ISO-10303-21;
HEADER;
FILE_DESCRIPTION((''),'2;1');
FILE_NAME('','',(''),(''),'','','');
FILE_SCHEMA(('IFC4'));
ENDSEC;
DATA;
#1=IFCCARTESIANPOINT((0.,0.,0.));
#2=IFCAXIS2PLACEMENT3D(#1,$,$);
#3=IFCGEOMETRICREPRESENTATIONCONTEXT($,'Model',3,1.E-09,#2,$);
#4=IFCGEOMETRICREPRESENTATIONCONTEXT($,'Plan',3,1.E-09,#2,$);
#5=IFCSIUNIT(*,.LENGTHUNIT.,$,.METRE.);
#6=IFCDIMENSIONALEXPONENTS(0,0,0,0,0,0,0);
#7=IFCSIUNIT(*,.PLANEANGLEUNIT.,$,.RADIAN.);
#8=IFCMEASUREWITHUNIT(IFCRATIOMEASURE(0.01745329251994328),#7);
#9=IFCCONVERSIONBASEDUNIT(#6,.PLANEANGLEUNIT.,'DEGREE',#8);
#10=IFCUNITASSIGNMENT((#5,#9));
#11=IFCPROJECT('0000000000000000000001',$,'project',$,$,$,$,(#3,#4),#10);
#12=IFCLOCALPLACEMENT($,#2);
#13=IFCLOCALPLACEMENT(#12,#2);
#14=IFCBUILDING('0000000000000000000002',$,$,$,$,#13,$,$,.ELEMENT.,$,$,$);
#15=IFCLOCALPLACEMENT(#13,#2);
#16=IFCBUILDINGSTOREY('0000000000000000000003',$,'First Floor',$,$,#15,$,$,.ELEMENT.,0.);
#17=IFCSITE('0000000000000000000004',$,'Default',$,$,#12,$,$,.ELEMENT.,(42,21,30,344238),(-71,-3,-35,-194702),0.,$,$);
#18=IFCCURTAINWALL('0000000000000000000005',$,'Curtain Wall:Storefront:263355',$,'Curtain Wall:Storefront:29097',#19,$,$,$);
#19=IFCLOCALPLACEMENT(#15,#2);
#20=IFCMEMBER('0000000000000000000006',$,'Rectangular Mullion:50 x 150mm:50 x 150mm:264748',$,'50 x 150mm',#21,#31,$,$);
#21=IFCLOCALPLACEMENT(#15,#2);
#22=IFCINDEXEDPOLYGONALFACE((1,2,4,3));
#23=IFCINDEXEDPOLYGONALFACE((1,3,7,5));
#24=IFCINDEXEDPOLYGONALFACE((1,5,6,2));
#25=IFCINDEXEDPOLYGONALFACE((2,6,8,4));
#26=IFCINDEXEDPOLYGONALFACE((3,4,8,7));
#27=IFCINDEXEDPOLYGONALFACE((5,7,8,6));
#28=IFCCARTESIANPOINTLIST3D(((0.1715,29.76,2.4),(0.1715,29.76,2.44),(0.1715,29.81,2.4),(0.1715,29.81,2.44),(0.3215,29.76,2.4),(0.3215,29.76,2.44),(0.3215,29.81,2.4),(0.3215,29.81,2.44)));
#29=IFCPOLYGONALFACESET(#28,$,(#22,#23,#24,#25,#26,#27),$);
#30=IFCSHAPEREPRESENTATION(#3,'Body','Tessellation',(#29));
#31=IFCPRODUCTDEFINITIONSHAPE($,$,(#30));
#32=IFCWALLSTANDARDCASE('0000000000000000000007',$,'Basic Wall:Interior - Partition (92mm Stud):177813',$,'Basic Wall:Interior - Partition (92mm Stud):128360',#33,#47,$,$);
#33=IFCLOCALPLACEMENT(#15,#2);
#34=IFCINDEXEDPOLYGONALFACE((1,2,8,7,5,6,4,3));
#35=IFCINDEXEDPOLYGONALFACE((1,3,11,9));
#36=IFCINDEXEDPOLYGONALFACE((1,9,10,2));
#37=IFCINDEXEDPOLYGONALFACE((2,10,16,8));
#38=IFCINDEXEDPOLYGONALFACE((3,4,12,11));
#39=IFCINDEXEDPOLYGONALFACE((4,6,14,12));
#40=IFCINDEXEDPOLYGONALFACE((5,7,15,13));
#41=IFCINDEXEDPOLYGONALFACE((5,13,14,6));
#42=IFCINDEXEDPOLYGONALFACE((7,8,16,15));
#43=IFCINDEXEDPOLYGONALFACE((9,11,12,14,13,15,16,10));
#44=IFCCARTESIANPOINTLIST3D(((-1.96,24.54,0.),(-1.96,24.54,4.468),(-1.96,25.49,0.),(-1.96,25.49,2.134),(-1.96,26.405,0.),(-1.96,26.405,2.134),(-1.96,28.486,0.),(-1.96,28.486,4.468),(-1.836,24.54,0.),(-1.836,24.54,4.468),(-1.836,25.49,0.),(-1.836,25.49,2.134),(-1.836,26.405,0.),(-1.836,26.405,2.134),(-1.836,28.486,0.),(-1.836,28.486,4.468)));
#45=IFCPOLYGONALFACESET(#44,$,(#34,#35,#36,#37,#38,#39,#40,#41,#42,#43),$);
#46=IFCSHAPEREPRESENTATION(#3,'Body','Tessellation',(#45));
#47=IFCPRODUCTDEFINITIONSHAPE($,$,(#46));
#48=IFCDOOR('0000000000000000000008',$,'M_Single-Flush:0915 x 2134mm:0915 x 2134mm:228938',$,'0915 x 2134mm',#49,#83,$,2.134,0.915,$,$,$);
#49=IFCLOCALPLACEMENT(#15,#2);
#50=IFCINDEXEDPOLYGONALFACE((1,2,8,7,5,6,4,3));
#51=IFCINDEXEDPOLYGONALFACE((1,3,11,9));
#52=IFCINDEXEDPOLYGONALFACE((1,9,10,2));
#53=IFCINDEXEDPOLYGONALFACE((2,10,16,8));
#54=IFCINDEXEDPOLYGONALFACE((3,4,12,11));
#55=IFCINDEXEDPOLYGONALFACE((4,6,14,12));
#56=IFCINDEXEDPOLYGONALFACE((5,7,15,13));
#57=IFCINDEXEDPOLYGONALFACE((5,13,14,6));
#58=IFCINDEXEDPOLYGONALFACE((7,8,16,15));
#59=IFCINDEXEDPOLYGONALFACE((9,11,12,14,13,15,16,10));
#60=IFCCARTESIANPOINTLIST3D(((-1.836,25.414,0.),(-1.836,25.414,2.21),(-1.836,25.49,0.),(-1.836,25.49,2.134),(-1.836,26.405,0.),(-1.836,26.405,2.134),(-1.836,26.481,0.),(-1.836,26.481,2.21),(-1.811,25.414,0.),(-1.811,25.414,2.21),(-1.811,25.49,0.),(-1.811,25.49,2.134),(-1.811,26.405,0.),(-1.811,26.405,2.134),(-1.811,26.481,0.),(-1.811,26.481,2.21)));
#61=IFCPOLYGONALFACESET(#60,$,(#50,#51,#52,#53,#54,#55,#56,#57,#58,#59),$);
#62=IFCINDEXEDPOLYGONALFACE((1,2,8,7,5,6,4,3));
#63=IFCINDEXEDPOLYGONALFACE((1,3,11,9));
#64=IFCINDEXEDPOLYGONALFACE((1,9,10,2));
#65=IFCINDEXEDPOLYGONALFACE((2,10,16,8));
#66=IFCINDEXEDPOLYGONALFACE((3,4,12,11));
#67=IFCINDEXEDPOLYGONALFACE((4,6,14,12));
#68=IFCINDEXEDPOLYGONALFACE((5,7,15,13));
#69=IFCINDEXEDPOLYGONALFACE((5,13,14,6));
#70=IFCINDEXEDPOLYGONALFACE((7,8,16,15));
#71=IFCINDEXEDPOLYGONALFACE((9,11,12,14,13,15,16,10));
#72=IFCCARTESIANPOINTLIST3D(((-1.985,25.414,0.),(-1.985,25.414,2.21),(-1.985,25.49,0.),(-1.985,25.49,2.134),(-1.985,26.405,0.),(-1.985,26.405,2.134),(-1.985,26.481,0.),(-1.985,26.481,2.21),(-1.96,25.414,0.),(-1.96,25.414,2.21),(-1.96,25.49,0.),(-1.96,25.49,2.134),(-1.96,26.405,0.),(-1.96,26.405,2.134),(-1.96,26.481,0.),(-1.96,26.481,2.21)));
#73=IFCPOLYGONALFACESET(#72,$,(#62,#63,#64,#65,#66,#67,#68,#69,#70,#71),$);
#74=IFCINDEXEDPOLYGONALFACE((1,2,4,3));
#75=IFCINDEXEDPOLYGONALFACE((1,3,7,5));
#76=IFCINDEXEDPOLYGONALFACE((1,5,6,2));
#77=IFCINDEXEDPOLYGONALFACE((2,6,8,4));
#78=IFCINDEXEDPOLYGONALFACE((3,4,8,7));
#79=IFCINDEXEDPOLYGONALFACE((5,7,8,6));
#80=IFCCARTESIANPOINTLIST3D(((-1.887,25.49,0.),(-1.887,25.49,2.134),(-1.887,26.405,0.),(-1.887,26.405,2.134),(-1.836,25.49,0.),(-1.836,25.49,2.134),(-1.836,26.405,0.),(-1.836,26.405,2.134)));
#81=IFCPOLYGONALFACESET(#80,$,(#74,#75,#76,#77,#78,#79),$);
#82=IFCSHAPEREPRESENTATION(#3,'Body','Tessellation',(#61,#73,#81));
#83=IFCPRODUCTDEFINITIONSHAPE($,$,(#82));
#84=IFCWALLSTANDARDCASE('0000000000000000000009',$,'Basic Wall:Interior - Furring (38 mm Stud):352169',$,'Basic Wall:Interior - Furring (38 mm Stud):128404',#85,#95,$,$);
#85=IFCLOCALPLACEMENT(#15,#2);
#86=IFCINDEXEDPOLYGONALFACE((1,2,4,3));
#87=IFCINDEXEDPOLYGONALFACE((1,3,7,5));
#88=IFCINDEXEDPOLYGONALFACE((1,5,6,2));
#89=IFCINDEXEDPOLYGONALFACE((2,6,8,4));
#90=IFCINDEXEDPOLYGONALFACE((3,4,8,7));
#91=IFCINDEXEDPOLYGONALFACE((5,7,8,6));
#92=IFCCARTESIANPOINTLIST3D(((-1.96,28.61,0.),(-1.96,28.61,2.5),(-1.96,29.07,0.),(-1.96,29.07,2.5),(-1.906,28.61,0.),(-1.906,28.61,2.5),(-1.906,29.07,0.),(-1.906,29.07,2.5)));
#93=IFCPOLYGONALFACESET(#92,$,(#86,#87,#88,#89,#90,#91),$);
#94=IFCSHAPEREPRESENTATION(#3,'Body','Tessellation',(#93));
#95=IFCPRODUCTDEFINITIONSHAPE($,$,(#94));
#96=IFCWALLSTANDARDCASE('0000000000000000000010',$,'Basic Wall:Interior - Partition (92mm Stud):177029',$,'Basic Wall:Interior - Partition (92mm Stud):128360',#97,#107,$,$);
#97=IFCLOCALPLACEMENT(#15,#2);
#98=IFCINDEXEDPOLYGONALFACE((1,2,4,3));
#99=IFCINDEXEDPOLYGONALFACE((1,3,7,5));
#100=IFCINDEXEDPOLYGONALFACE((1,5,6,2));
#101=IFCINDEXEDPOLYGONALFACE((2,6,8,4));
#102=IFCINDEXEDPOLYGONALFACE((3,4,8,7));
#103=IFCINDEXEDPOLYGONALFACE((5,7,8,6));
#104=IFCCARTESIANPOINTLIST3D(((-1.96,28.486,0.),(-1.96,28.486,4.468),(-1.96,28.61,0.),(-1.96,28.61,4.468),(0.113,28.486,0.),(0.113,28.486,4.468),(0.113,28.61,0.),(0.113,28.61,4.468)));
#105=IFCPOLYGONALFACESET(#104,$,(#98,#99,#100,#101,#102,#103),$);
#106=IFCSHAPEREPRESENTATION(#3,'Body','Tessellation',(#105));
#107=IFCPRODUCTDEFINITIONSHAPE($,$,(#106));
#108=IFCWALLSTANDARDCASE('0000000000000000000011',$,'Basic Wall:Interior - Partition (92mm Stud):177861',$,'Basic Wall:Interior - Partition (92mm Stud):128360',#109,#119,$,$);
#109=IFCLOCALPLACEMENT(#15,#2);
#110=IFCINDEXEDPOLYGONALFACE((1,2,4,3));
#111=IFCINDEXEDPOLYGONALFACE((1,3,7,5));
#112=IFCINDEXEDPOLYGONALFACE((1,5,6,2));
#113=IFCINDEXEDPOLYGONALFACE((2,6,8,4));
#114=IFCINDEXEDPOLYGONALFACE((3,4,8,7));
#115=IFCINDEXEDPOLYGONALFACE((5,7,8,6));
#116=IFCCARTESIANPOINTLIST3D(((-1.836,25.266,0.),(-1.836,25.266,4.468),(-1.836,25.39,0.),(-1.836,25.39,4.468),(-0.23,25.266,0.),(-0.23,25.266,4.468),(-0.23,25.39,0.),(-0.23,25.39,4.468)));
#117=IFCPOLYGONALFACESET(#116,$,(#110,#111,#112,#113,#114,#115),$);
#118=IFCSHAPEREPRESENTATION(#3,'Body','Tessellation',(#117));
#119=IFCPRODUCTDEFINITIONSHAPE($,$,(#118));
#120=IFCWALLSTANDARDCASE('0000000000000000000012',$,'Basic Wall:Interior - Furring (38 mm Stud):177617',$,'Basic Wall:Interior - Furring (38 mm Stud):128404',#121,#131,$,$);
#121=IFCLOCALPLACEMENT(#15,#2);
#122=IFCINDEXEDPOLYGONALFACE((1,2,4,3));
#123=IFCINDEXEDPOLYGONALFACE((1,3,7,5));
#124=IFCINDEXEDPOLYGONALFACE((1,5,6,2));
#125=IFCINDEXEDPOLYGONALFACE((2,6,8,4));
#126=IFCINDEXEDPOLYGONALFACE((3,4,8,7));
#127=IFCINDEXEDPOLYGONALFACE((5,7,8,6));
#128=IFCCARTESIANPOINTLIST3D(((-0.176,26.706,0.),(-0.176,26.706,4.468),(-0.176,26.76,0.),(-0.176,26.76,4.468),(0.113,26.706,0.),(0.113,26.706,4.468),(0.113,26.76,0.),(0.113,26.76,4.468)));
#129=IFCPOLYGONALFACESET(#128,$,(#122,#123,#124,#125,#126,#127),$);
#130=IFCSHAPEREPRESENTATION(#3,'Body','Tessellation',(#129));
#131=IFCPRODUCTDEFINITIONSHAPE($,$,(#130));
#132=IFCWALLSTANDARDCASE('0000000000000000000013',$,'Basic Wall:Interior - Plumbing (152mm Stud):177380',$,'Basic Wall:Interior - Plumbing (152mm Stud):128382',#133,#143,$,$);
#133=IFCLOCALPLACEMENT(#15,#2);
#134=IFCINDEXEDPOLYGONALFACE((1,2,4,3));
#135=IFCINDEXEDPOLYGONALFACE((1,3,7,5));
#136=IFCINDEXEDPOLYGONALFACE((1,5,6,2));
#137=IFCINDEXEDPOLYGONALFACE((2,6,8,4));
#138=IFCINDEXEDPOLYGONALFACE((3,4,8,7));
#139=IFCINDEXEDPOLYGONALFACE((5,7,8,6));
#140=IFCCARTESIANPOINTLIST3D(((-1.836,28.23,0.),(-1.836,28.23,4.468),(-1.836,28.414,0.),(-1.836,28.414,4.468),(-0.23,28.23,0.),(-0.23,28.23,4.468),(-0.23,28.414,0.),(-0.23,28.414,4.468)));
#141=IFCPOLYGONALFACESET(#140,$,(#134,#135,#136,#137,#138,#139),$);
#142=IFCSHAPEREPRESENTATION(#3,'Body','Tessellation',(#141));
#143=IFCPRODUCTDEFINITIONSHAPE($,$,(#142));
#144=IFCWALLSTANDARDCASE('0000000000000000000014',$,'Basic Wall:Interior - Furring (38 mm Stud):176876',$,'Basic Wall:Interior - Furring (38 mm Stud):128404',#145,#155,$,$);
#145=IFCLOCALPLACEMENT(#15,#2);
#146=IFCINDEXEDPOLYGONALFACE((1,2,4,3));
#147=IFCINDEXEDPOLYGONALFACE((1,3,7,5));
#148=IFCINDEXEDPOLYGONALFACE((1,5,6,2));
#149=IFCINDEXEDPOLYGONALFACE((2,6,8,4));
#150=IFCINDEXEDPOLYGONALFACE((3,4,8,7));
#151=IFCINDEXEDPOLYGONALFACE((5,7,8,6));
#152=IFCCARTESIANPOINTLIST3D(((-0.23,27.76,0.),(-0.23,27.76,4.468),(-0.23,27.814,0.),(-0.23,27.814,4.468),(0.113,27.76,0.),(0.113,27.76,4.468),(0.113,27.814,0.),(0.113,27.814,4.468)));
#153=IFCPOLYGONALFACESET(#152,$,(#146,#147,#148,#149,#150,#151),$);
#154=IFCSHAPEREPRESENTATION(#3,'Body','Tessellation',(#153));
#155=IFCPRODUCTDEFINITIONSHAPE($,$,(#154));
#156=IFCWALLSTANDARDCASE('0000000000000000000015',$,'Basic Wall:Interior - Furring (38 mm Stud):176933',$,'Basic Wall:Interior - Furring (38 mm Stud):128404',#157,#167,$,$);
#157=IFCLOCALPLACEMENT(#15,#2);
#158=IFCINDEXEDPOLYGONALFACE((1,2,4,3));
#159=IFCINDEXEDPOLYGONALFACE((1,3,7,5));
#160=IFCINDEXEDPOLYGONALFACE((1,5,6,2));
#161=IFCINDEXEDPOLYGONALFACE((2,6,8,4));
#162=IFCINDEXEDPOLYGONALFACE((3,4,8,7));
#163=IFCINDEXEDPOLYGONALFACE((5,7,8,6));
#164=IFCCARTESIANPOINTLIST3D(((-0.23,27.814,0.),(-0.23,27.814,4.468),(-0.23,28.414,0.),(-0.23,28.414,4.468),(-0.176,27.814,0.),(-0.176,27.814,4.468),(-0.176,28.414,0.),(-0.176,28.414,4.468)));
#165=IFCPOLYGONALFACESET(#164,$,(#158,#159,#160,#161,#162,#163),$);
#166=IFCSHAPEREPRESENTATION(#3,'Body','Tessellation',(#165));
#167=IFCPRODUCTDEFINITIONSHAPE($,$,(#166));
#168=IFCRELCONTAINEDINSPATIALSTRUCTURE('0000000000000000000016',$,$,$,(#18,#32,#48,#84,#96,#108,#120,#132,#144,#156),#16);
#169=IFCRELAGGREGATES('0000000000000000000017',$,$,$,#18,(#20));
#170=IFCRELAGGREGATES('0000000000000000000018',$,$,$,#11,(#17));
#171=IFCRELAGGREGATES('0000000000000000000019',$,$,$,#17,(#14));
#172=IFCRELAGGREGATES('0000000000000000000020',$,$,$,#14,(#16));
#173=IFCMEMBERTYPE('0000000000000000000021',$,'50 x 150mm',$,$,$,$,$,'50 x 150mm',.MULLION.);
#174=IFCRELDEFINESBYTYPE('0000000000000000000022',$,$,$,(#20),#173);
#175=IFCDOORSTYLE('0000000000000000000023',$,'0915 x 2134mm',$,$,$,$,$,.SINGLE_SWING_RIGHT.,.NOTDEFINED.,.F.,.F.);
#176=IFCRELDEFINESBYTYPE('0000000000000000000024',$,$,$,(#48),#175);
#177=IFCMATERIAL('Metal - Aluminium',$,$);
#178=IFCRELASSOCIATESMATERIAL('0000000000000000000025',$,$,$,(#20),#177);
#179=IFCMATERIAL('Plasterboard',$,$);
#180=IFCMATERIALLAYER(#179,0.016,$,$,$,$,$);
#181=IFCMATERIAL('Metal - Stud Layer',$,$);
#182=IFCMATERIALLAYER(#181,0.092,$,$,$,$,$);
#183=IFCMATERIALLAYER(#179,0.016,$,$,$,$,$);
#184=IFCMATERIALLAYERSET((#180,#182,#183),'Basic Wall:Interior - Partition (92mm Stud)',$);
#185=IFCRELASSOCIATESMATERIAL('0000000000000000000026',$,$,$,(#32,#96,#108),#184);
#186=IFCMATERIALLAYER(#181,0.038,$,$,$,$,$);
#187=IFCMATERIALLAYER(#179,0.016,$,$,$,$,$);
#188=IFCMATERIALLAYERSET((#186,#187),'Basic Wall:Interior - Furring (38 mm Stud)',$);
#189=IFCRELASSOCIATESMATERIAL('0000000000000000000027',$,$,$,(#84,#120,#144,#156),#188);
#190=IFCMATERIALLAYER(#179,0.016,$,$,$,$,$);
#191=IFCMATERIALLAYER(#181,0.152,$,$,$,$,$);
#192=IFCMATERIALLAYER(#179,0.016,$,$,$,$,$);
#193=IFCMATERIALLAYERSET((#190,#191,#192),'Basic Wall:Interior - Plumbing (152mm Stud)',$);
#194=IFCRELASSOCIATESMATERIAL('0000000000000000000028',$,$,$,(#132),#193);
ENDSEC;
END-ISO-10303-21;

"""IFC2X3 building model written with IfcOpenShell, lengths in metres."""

from ifc_helpers import new_model, entity, si_unit, converted_unit, frame, frame_2d, origin, origin_2d_with_axis, place, context, project, spatial, polyline, rectangle, outline, extrude, source, transform, mapped, material, layer, layer_set, layer_usage, type_object, type_shapes, element, fill, aggregate, save


model = new_model("IFC2X3")

# Units and contexts
model_context = context("Model", 3, precision=1e-09, world=origin())
plan_context = context("Plan", 3, precision=1e-09, world=origin())
ifc_project = project(units=[si_unit("LENGTHUNIT", "METRE"), converted_unit("PLANEANGLEUNIT", "DEGREE", entity("IfcRatioMeasure", 0.01745329251994328), si_unit("PLANEANGLEUNIT", "RADIAN"), dimensions=[0, 0, 0, 0, 0, 0, 0])], contexts=[model_context, plan_context])

# Site, building, storey
site_placement = place(None, origin())
site = spatial("IfcSite", under=ifc_project, at=site_placement, Name="Default", CompositionType="ELEMENT", RefLatitude=(42, 21, 30, 344238), RefLongitude=(-71, -3, -35, -194702), RefElevation=0.0)
building_placement = place(site_placement, origin())
building = spatial("IfcBuilding", under=site, at=building_placement, CompositionType="ELEMENT")
storey_placement = place(building_placement, origin())
storey = spatial("IfcBuildingStorey", under=building, at=storey_placement, Name="First Floor", CompositionType="ELEMENT", Elevation=0.0)

# Curtain wall, member
curtain_wall_placement = place(storey_placement, origin())
curtain_wall = element("IfcCurtainWall", 1, at=curtain_wall_placement, inside=storey, Name="Curtain Wall:Storefront:263355", ObjectType="Curtain Wall:Storefront:29097")
ifc_material_1 = material(Name="Metal - Aluminium")
member_type_1 = type_object("IfcMemberType", Name="50 x 150mm", ElementType="50 x 150mm", PredefinedType="MULLION")
shared_shape_1 = source(origin(), model_context, "Body", "SweptSolid", [
    extrude(rectangle(XDim=0.05, YDim=0.15, at=origin_2d_with_axis()), frame((-0.025, 0.0, -0.04), z_axis=(0.0, 0.0, 1.0), x_axis=(-1.0, 0.0, 0.0)), (0.0, 0.0, 1.0), 0.04),
])
type_shapes(member_type_1, [shared_shape_1])
member_1_placement = place(storey_placement, frame((0.2465, 29.76, 2.4), z_axis=(0.0, 0.0, -1.0), x_axis=(0.0, -1.0, 0.0)))
member_1 = element("IfcMember", 2, at=member_1_placement, type_object=member_type_1, material=ifc_material_1, Name="Rectangular Mullion:50 x 150mm:50 x 150mm:264748", ObjectType="50 x 150mm", context=model_context, shape_type="MappedRepresentation", body=[
    mapped(shared_shape_1, transform((0.0, 0.0, 0.0), scale=1.0)),
])
aggregate(curtain_wall, [member_1])

# Wall, opening, door
ifc_material_2 = material(Name="Plasterboard")
ifc_layer_1 = layer(ifc_material_2, 0.016)
ifc_material_3 = material(Name="Metal - Stud Layer")
ifc_layer_2 = layer(ifc_material_3, 0.092)
ifc_layer_3 = layer(ifc_material_2, 0.016)
ifc_layer_set_1 = layer_set([ifc_layer_1, ifc_layer_2, ifc_layer_3], Name="Basic Wall:Interior - Partition (92mm Stud)")
ifc_layer_usage_1 = layer_usage(ifc_layer_set_1, "AXIS2", "NEGATIVE", 0.062)
wall_1_placement = place(storey_placement, frame((-1.898, 24.54, 0.0), z_axis=(0.0, 0.0, 1.0), x_axis=(0.0, 1.0, 0.0)))
wall_1 = element("IfcWallStandardCase", 3, at=wall_1_placement, inside=storey, material=ifc_layer_usage_1, Name="Basic Wall:Interior - Partition (92mm Stud):177813", ObjectType="Basic Wall:Interior - Partition (92mm Stud):128360", context=model_context, shape_type="SweptSolid", body=[
    extrude(rectangle(XDim=3.946, YDim=0.124, at=frame_2d((1.973, 0.0), x_axis=(-1.0, 0.0))), origin(), (0.0, 0.0, 1.0), 4.468),
])
opening_1_placement = place(wall_1_placement, frame((1.865, 0.062, 0.0)))
opening_1 = element("IfcOpeningElement", 4, at=opening_1_placement, cuts=wall_1, ObjectType="Opening", context=model_context, shape_type="SweptSolid", body=[
    extrude(rectangle(XDim=0.915, YDim=2.134, at=frame_2d((1.067, 0.4575), x_axis=(0.0, 1.0))), frame((0.0, 0.0, 0.0), z_axis=(0.0, -1.0, 0.0), x_axis=(0.0, 0.0, 1.0)), (0.0, 0.0, 1.0), 0.124),
])
door_style = type_object("IfcDoorStyle", Name="0915 x 2134mm", ConstructionType="NOTDEFINED", OperationType="SINGLE_SWING_RIGHT", ParameterTakesPrecedence=False, Sizeable=False)
shared_shape_2 = source(origin(), model_context, "Body", "SweptSolid", [
    extrude(outline(polyline([(-0.5335, -1.124), (0.5335, -1.124), (0.5335, 1.086), (0.4575, 1.086), (0.4575, -1.048), (-0.4575, -1.048), (-0.4575, 1.086), (-0.5335, 1.086), (-0.5335, -1.124)])), frame((0.4575, 0.124, 1.086), z_axis=(0.0, 1.0, 0.0), x_axis=(1.0, 0.0, 0.0)), (0.0, 0.0, 1.0), 0.025),
    extrude(outline(polyline([(-1.124, -0.5335), (1.086, -0.5335), (1.086, -0.4575), (-1.048, -0.4575), (-1.048, 0.4575), (1.086, 0.4575), (1.086, 0.5335), (-1.124, 0.5335), (-1.124, -0.5335)])), frame((0.4575, -0.025, 1.086), z_axis=(0.0, 1.0, 0.0), x_axis=(0.0, 0.0, -1.0)), (0.0, 0.0, 1.0), 0.025),
    extrude(rectangle(XDim=0.051, YDim=0.915, at=origin_2d_with_axis()), frame((0.4575, 0.0985, 0.0), z_axis=(0.0, 0.0, 1.0), x_axis=(0.0, 1.0, 0.0)), (0.0, 0.0, 1.0), 2.134),
])
type_shapes(door_style, [shared_shape_2])
door_placement = place(opening_1_placement, frame((0.0, 0.0, 0.0), z_axis=(0.0, 0.0, 1.0), x_axis=(-1.0, 0.0, 0.0)))
door = element("IfcDoor", 5, at=door_placement, inside=storey, type_object=door_style, Name="M_Single-Flush:0915 x 2134mm:0915 x 2134mm:228938", ObjectType="0915 x 2134mm", OverallHeight=2.134, OverallWidth=0.915, context=model_context, shape_type="MappedRepresentation", body=[
    mapped(shared_shape_2, transform((0.0, 0.0, 0.0), scale=1.0)),
])
fill(opening_1, door)

# Walls
ifc_layer_4 = layer(ifc_material_3, 0.038)
ifc_layer_5 = layer(ifc_material_2, 0.016)
ifc_layer_set_2 = layer_set([ifc_layer_4, ifc_layer_5], Name="Basic Wall:Interior - Furring (38 mm Stud)")
ifc_layer_usage_2 = layer_usage(ifc_layer_set_2, "AXIS2", "POSITIVE", -0.027)
wall_2_placement = place(storey_placement, frame((-1.933, 28.61, 0.0), z_axis=(0.0, 0.0, 1.0), x_axis=(0.0, 1.0, 0.0)))
element("IfcWallStandardCase", 6, at=wall_2_placement, inside=storey, material=ifc_layer_usage_2, Name="Basic Wall:Interior - Furring (38 mm Stud):352169", ObjectType="Basic Wall:Interior - Furring (38 mm Stud):128404", context=model_context, shape_type="SweptSolid", body=[
    extrude(rectangle(XDim=0.46, YDim=0.054, at=frame_2d((0.23, 0.0), x_axis=(-1.0, 0.0))), origin(), (0.0, 0.0, 1.0), 2.5),
])
wall_3_placement = place(storey_placement, frame((-1.96, 28.548, 0.0)))
element("IfcWallStandardCase", 7, at=wall_3_placement, inside=storey, material=ifc_layer_usage_1, Name="Basic Wall:Interior - Partition (92mm Stud):177029", ObjectType="Basic Wall:Interior - Partition (92mm Stud):128360", context=model_context, shape_type="SweptSolid", body=[
    extrude(rectangle(XDim=2.073, YDim=0.124, at=frame_2d((1.0365, 0.0), x_axis=(-1.0, 0.0))), origin(), (0.0, 0.0, 1.0), 4.468),
])
wall_4_placement = place(storey_placement, frame((-1.836, 25.328, 0.0)))
element("IfcWallStandardCase", 8, at=wall_4_placement, inside=storey, material=ifc_layer_usage_1, Name="Basic Wall:Interior - Partition (92mm Stud):177861", ObjectType="Basic Wall:Interior - Partition (92mm Stud):128360", context=model_context, shape_type="SweptSolid", body=[
    extrude(rectangle(XDim=1.606, YDim=0.124, at=frame_2d((0.803, 0.0), x_axis=(-1.0, 0.0))), origin(), (0.0, 0.0, 1.0), 4.468),
])
wall_5_placement = place(storey_placement, frame((-0.176, 26.733, 0.0)))
element("IfcWallStandardCase", 9, at=wall_5_placement, inside=storey, material=ifc_layer_usage_2, Name="Basic Wall:Interior - Furring (38 mm Stud):177617", ObjectType="Basic Wall:Interior - Furring (38 mm Stud):128404", context=model_context, shape_type="SweptSolid", body=[
    extrude(rectangle(XDim=0.289, YDim=0.054, at=frame_2d((0.1445, 0.0), x_axis=(-1.0, 0.0))), origin(), (0.0, 0.0, 1.0), 4.468),
])
ifc_layer_6 = layer(ifc_material_2, 0.016)
ifc_layer_7 = layer(ifc_material_3, 0.152)
ifc_layer_8 = layer(ifc_material_2, 0.016)
ifc_layer_set_3 = layer_set([ifc_layer_6, ifc_layer_7, ifc_layer_8], Name="Basic Wall:Interior - Plumbing (152mm Stud)")
ifc_layer_usage_3 = layer_usage(ifc_layer_set_3, "AXIS2", "NEGATIVE", 0.092)
wall_6_placement = place(storey_placement, frame((-0.23, 28.322, 0.0), z_axis=(0.0, 0.0, 1.0), x_axis=(-1.0, 0.0, 0.0)))
element("IfcWallStandardCase", 10, at=wall_6_placement, inside=storey, material=ifc_layer_usage_3, Name="Basic Wall:Interior - Plumbing (152mm Stud):177380", ObjectType="Basic Wall:Interior - Plumbing (152mm Stud):128382", context=model_context, shape_type="SweptSolid", body=[
    extrude(rectangle(XDim=1.606, YDim=0.184, at=frame_2d((0.803, 0.0), x_axis=(-1.0, 0.0))), origin(), (0.0, 0.0, 1.0), 4.468),
])
wall_7_placement = place(storey_placement, frame((0.113, 27.787, 0.0), z_axis=(0.0, 0.0, 1.0), x_axis=(-1.0, 0.0, 0.0)))
element("IfcWallStandardCase", 11, at=wall_7_placement, inside=storey, material=ifc_layer_usage_2, Name="Basic Wall:Interior - Furring (38 mm Stud):176876", ObjectType="Basic Wall:Interior - Furring (38 mm Stud):128404", context=model_context, shape_type="SweptSolid", body=[
    extrude(rectangle(XDim=0.343, YDim=0.054, at=frame_2d((0.1715, 0.0), x_axis=(-1.0, 0.0))), origin(), (0.0, 0.0, 1.0), 4.468),
])
wall_8_placement = place(storey_placement, frame((-0.203, 27.814, 0.0), z_axis=(0.0, 0.0, 1.0), x_axis=(0.0, 1.0, 0.0)))
element("IfcWallStandardCase", 12, at=wall_8_placement, inside=storey, material=ifc_layer_usage_2, Name="Basic Wall:Interior - Furring (38 mm Stud):176933", ObjectType="Basic Wall:Interior - Furring (38 mm Stud):128404", context=model_context, shape_type="SweptSolid", body=[
    extrude(rectangle(XDim=0.6, YDim=0.054, at=frame_2d((0.3, 0.0), x_axis=(-1.0, 0.0))), origin(), (0.0, 0.0, 1.0), 4.468),
])

save(model, "model.ifc")
